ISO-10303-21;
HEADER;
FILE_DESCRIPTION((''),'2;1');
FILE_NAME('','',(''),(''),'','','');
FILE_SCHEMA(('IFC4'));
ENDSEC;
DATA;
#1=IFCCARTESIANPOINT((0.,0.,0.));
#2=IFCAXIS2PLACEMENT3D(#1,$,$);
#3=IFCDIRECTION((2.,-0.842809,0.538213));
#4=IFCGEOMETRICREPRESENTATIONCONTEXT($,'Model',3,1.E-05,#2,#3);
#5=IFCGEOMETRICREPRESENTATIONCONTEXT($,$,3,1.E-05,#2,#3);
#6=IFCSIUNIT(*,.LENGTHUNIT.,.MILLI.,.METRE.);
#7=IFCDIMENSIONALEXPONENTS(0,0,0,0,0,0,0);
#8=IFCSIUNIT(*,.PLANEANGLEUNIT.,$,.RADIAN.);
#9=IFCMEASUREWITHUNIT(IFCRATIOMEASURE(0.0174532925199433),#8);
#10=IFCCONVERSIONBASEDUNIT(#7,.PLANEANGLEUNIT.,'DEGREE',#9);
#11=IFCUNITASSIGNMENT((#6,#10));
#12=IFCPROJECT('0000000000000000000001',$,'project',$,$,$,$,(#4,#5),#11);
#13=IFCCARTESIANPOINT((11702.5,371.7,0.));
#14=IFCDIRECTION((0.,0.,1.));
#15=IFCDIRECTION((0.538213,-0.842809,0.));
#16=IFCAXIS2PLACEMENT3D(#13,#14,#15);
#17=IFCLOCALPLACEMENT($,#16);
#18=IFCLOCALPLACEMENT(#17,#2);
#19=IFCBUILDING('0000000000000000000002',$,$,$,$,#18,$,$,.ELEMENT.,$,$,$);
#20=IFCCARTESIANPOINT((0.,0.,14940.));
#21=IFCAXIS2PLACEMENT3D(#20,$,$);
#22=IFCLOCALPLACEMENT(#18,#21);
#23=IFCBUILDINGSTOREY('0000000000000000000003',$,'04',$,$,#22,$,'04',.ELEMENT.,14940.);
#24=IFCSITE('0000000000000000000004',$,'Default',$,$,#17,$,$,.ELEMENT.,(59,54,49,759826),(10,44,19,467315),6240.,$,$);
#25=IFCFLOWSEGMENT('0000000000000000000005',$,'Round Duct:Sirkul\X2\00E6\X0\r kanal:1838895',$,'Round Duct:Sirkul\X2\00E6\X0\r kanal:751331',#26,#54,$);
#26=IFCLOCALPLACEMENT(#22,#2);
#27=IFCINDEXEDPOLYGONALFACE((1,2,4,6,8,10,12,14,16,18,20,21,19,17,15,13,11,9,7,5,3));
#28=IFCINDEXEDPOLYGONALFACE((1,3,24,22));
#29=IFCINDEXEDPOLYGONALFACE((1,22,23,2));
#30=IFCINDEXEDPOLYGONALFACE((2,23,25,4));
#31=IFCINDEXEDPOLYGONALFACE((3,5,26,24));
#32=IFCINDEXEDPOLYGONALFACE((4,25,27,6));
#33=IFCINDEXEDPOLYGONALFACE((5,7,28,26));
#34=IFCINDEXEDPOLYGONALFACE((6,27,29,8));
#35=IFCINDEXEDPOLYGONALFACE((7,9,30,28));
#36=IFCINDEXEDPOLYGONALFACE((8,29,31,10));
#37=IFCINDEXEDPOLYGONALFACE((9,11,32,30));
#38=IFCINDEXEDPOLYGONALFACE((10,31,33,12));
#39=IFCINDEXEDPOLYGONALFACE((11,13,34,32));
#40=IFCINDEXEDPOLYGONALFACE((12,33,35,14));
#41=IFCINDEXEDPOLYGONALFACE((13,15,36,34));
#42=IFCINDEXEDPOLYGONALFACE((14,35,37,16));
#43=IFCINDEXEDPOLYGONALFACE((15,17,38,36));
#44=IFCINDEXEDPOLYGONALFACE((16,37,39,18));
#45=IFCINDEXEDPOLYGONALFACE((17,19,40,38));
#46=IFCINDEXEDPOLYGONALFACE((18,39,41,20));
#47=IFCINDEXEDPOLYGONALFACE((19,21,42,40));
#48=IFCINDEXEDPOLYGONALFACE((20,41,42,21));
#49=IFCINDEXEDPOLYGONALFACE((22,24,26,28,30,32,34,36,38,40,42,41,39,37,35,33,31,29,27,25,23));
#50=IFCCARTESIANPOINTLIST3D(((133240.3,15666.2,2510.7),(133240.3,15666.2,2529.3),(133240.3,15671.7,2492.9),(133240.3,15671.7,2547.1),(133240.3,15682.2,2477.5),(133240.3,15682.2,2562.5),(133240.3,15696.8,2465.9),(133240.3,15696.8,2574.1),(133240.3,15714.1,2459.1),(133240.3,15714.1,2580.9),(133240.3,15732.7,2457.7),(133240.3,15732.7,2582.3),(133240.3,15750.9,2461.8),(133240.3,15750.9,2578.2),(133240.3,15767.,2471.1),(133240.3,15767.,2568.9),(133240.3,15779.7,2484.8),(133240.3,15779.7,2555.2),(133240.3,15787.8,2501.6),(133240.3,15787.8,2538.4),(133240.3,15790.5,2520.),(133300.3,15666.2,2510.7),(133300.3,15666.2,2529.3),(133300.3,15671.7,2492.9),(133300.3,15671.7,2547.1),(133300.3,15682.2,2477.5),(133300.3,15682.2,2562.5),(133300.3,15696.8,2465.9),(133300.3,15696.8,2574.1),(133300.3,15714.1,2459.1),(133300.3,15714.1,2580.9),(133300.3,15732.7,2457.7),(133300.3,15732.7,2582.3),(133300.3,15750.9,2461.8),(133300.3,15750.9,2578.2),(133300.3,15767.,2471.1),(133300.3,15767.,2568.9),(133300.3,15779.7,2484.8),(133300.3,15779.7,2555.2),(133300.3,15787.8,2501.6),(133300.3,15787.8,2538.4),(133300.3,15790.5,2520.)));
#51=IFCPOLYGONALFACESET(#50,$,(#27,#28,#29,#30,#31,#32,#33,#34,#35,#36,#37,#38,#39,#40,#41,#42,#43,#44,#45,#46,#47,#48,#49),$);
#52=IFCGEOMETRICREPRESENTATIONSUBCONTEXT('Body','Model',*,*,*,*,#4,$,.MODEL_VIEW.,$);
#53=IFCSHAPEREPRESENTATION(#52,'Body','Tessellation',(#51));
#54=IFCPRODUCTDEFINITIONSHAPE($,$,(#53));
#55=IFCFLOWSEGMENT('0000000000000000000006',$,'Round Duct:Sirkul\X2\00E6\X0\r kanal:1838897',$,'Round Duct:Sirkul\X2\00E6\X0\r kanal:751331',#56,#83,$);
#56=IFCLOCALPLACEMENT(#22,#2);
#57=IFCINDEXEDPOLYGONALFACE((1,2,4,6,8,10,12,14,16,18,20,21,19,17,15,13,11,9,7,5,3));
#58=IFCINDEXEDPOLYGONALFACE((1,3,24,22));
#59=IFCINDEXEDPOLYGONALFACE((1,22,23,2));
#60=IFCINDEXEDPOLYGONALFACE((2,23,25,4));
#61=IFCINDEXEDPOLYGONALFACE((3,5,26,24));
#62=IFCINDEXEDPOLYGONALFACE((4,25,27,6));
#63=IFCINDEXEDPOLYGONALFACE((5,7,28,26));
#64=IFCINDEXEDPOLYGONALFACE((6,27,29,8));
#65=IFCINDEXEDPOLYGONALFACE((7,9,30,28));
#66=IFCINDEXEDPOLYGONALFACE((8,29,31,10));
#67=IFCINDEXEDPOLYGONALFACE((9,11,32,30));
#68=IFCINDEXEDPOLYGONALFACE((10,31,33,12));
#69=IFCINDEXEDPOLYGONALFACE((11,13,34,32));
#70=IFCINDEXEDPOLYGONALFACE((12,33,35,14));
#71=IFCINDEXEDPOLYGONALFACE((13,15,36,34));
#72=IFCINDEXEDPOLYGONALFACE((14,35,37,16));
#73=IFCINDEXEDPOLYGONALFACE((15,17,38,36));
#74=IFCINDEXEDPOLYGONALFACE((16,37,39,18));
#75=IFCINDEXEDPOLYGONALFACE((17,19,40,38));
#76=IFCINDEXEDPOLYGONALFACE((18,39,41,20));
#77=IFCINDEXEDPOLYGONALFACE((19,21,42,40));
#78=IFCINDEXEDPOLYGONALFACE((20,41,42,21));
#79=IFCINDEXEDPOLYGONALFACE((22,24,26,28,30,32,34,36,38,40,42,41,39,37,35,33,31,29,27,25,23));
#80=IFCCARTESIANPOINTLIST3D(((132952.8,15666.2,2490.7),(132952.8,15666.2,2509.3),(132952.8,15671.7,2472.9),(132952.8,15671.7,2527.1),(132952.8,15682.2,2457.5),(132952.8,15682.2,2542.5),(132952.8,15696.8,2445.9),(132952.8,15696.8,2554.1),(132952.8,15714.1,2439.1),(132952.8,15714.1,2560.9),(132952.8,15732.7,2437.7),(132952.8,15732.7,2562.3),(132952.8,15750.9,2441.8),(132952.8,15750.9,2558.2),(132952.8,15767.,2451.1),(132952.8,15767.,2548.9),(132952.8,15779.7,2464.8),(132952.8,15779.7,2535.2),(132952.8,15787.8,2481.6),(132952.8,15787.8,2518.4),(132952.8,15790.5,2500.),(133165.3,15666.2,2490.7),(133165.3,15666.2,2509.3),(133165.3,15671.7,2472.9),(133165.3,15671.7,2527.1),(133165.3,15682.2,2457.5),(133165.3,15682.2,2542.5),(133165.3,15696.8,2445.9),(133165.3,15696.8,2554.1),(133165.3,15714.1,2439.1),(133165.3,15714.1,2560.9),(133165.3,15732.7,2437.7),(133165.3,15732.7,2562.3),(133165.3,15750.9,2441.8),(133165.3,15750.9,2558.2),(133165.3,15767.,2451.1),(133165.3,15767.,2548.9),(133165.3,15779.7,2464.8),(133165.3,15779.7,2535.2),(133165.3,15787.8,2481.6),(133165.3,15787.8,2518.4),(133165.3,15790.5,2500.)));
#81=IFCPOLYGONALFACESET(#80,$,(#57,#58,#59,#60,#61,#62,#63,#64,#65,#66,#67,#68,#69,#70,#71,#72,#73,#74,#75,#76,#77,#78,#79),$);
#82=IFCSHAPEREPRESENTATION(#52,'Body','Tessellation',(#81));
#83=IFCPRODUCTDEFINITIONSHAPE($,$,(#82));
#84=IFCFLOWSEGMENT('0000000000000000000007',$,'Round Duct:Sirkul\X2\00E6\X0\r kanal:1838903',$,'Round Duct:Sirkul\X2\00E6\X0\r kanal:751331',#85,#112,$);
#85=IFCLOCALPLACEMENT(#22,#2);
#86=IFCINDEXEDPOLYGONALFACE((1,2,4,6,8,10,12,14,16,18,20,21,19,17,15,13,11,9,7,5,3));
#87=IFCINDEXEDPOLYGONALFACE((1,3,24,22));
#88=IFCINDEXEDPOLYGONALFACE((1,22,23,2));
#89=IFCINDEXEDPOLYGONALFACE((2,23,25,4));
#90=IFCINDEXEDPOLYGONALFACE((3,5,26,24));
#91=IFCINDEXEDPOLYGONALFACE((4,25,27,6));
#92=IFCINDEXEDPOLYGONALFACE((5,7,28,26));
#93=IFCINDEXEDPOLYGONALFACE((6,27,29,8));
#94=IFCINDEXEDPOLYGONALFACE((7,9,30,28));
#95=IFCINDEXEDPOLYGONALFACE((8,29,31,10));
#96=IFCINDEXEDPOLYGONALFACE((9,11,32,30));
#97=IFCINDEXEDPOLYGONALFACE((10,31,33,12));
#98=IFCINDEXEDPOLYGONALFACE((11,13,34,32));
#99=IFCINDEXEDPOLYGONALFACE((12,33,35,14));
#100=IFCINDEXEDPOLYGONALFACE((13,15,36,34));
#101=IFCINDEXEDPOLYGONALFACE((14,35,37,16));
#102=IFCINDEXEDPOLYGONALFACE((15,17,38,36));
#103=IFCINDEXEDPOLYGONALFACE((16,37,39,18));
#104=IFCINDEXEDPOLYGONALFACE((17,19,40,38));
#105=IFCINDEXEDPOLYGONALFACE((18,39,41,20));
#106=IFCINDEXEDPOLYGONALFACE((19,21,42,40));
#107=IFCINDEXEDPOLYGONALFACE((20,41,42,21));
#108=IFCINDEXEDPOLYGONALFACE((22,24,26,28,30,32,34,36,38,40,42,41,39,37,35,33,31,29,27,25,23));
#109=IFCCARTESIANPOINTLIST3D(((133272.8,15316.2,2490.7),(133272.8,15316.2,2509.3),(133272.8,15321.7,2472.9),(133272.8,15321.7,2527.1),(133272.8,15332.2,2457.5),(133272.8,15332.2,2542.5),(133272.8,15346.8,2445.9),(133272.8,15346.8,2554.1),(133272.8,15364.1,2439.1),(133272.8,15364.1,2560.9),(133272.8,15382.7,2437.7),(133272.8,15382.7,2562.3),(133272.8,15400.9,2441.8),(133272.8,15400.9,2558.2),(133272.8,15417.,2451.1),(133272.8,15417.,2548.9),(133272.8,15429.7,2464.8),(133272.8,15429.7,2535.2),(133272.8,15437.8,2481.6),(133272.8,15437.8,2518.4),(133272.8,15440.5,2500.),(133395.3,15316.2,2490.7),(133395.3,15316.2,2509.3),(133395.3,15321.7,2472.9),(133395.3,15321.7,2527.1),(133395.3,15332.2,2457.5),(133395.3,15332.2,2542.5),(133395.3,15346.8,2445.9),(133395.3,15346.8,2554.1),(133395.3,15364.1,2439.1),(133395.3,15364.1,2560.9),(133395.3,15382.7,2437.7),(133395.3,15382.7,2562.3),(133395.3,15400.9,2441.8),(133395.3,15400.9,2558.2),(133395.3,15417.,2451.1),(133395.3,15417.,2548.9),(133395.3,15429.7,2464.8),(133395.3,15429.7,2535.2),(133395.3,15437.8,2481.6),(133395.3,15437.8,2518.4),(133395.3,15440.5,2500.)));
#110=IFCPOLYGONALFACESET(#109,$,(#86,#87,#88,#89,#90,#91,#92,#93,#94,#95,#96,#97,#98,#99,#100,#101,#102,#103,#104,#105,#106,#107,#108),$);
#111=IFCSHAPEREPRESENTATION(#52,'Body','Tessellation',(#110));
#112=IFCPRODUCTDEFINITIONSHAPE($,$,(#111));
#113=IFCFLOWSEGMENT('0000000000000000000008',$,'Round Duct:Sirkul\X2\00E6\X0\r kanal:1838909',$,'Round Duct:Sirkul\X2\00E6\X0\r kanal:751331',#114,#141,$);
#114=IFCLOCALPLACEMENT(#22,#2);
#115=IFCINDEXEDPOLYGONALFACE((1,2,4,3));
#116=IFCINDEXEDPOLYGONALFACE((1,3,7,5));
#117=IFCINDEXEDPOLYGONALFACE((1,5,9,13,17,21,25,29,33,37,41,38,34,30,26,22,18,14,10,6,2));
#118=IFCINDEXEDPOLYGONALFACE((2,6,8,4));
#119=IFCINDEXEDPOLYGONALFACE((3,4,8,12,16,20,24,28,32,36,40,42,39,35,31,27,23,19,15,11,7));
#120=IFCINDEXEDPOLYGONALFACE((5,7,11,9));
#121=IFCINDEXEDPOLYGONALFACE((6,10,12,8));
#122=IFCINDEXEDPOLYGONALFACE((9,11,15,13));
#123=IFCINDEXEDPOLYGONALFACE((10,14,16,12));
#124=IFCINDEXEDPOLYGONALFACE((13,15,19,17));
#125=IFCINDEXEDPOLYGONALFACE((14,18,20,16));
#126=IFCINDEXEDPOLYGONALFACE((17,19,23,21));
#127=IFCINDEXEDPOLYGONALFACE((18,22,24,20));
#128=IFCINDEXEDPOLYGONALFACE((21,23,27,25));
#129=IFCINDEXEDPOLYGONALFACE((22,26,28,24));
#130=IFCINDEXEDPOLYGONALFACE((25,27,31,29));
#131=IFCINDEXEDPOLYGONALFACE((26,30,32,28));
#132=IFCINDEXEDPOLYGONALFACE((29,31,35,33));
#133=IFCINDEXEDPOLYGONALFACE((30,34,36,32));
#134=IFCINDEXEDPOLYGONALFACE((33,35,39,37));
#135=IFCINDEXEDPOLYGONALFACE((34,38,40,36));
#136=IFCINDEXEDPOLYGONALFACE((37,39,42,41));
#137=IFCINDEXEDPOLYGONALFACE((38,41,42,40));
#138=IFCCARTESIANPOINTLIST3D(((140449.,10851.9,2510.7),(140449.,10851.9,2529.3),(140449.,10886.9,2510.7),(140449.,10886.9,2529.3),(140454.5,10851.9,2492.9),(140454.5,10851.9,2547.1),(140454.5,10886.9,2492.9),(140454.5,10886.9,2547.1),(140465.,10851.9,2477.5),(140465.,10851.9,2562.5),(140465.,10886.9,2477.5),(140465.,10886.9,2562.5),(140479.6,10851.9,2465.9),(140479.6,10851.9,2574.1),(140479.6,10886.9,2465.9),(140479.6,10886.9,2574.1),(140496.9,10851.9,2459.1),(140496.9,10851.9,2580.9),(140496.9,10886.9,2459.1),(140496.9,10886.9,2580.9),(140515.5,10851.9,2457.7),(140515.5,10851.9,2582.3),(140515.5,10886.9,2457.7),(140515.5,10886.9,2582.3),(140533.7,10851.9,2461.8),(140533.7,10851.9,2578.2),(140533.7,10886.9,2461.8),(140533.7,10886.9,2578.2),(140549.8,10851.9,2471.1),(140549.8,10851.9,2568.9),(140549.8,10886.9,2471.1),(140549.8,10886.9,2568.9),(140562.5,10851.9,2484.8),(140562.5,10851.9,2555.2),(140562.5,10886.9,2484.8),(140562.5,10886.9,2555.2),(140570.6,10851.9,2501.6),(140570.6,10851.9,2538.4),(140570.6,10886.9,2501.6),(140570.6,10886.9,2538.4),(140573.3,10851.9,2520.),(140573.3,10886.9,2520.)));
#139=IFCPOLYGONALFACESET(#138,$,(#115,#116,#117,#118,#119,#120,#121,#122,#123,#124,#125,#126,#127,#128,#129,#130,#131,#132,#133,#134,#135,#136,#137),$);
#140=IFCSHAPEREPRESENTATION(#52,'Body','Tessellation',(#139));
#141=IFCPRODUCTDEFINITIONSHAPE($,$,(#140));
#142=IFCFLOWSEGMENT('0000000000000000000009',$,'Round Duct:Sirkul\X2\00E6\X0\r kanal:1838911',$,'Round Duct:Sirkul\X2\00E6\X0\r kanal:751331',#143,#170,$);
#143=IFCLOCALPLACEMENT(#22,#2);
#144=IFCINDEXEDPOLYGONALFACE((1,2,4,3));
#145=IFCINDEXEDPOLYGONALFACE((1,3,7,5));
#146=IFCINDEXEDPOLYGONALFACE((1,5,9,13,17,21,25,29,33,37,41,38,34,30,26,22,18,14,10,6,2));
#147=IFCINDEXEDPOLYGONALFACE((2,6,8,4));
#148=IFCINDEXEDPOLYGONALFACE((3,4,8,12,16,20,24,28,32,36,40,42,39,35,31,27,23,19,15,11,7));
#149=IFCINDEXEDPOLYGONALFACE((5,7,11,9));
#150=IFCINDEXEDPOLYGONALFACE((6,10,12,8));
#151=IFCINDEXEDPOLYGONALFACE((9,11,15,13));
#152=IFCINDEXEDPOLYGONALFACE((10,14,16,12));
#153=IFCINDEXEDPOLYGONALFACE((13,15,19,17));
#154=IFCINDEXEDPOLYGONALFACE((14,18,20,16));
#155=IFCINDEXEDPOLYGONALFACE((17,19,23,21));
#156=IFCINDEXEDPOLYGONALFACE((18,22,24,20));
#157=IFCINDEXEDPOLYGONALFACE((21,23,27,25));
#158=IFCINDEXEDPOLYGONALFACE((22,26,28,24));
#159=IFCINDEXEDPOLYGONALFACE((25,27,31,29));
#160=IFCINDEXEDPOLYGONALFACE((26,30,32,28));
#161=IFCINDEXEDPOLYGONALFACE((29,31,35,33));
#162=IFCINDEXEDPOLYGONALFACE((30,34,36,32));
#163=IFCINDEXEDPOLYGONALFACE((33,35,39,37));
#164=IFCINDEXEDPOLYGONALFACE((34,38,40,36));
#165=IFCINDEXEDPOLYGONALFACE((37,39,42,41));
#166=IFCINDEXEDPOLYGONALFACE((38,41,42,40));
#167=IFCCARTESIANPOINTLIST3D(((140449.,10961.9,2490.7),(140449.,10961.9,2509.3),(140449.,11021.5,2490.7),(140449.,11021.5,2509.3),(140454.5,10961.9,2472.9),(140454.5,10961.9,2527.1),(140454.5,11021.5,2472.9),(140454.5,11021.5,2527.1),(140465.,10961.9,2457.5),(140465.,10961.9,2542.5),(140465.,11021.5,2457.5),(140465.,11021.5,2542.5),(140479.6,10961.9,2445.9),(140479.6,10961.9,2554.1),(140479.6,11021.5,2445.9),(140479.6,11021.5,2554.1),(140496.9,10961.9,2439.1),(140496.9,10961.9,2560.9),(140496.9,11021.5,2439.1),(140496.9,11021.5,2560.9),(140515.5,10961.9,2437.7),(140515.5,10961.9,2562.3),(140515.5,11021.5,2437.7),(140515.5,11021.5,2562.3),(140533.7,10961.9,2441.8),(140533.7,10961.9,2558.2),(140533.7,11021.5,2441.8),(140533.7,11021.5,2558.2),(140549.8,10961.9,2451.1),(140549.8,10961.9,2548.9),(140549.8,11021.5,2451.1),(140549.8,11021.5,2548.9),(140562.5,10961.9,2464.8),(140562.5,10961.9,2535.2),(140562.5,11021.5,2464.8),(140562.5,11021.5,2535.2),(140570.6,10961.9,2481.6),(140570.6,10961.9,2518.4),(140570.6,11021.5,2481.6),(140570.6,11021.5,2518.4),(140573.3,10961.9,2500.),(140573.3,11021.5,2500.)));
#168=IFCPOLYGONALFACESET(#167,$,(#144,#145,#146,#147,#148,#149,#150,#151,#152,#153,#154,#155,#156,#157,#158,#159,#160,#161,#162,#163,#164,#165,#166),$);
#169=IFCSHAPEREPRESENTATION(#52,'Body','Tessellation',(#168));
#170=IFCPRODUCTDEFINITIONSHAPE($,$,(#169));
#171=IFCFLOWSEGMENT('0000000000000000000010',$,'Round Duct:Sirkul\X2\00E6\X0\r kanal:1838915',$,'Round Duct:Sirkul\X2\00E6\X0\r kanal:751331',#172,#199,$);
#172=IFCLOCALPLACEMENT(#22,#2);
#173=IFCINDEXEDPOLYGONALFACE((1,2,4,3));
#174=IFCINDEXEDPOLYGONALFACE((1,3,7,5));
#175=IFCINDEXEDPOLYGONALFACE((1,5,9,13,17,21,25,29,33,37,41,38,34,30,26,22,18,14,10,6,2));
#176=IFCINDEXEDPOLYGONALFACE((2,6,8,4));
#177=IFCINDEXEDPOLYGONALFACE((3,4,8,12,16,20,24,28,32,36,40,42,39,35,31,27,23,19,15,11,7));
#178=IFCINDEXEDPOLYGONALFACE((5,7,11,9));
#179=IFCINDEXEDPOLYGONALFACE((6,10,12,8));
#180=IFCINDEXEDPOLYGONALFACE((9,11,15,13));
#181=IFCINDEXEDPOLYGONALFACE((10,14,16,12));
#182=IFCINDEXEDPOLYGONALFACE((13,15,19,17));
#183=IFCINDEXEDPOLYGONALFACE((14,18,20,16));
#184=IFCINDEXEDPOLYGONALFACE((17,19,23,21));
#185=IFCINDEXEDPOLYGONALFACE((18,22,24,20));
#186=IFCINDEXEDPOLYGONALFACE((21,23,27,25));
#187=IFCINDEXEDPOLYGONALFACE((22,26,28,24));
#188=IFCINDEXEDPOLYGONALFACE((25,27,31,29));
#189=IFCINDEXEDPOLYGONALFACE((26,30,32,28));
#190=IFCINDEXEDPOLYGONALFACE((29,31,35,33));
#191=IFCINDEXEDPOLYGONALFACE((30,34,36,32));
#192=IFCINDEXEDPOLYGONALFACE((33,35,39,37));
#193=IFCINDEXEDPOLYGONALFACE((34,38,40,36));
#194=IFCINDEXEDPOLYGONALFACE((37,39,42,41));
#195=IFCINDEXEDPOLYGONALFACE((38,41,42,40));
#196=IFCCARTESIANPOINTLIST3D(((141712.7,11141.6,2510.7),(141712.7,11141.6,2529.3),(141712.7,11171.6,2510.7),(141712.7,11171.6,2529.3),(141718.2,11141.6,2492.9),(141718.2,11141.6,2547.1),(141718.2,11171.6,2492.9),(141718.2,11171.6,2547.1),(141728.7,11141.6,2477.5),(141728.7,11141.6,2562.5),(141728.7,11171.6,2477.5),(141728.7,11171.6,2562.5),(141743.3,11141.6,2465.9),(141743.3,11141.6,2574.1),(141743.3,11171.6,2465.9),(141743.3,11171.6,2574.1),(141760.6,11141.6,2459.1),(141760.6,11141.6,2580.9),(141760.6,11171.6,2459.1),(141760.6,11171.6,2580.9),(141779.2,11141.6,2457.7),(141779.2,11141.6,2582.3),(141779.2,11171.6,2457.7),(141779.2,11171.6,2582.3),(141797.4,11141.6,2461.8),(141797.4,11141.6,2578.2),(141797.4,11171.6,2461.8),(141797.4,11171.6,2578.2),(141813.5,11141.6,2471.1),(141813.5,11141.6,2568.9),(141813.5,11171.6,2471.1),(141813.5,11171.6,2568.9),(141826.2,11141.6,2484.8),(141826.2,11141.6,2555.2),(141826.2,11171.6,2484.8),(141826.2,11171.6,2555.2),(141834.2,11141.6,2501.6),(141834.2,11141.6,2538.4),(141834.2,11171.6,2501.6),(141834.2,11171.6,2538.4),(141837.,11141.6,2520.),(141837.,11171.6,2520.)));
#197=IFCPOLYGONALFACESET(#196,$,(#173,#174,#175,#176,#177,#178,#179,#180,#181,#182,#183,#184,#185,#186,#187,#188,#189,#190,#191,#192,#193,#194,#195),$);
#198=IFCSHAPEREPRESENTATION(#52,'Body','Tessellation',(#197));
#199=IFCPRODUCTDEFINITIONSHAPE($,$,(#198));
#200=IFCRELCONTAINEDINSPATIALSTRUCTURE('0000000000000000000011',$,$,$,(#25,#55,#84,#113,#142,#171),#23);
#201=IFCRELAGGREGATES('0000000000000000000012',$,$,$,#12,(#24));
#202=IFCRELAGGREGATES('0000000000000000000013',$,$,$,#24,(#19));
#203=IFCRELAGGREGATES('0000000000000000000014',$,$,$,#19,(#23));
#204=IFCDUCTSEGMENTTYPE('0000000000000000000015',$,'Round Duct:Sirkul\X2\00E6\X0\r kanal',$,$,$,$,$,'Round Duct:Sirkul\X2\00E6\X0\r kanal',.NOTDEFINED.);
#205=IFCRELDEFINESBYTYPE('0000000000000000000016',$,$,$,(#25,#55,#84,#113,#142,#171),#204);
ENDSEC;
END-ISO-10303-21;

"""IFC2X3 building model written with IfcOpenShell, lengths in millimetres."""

from ifc_helpers import new_model, entity, si_unit, converted_unit, direction, frame, frame_2d, origin, origin_2d_with_axis, place, context, subcontext, project, spatial, circle, extrude, type_object, element, save


model = new_model("IFC2X3")

# Units and contexts
model_context = context("Model", 3, precision=1e-05, world=origin(), true_north=direction((2.0, -0.842809, 0.538213)))
context_of_model = context(None, 3, precision=1e-05, world=origin(), true_north=direction((2.0, -0.842809, 0.538213)))
body_context = subcontext(model_context, "Body", "Model", "MODEL_VIEW")
ifc_project = project(units=[si_unit("LENGTHUNIT", "METRE", prefix="MILLI"), converted_unit("PLANEANGLEUNIT", "DEGREE", entity("IfcRatioMeasure", 0.0174532925199433), si_unit("PLANEANGLEUNIT", "RADIAN"), dimensions=[0, 0, 0, 0, 0, 0, 0])], contexts=[model_context, context_of_model])

# Site, building, storey
site_placement = place(None, frame((11702.5, 371.7, 0.0), z_axis=(0.0, 0.0, 1.0), x_axis=(0.538213, -0.842809, 0.0)))
site = spatial("IfcSite", under=ifc_project, at=site_placement, Name="Default", CompositionType="ELEMENT", RefLatitude=(59, 54, 49, 759826), RefLongitude=(10, 44, 19, 467315), RefElevation=6240.0)
building_placement = place(site_placement, origin())
building = spatial("IfcBuilding", under=site, at=building_placement, CompositionType="ELEMENT")
storey_placement = place(building_placement, frame((0.0, 0.0, 14940.0)))
storey = spatial("IfcBuildingStorey", under=building, at=storey_placement, Name="04", LongName="04", CompositionType="ELEMENT", Elevation=14940.0)

# Flow segments
duct_segment_type_1 = type_object("IfcDuctSegmentType", Name="Round Duct:Sirkulær kanal", ElementType="Round Duct:Sirkulær kanal", PredefinedType="NOTDEFINED")
flow_segment_1_placement = place(storey_placement, origin())
element("IfcFlowSegment", 1, at=flow_segment_1_placement, inside=storey, type_object=duct_segment_type_1, Name="Round Duct:Sirkulær kanal:1838895", ObjectType="Round Duct:Sirkulær kanal:751331", context=body_context, shape_type="SweptSolid", body=[
    extrude(circle(Radius=62.5, at=frame_2d((0.0, 0.0), x_axis=(1.0, 0.0))), frame((133240.3, 15728.0, 2520.0), z_axis=(1.0, 0.0, 0.0), x_axis=(0.0, 1.0, 0.0)), (0.0, 0.0, 1.0), 60.0),
])
flow_segment_2_placement = place(storey_placement, origin())
element("IfcFlowSegment", 2, at=flow_segment_2_placement, inside=storey, type_object=duct_segment_type_1, Name="Round Duct:Sirkulær kanal:1838897", ObjectType="Round Duct:Sirkulær kanal:751331", context=body_context, shape_type="SweptSolid", body=[
    extrude(circle(Radius=62.5, at=frame_2d((0.0, 0.0), x_axis=(1.0, 0.0))), frame((132952.8, 15728.0, 2500.0), z_axis=(1.0, 0.0, 0.0), x_axis=(0.0, 1.0, 0.0)), (0.0, 0.0, 1.0), 212.5),
])
flow_segment_3_placement = place(storey_placement, origin())
element("IfcFlowSegment", 3, at=flow_segment_3_placement, inside=storey, type_object=duct_segment_type_1, Name="Round Duct:Sirkulær kanal:1838903", ObjectType="Round Duct:Sirkulær kanal:751331", context=body_context, shape_type="SweptSolid", body=[
    extrude(circle(Radius=62.5, at=frame_2d((0.0, 0.0), x_axis=(1.0, 0.0))), frame((133272.8, 15378.0, 2500.0), z_axis=(1.0, 0.0, 0.0), x_axis=(0.0, 1.0, 0.0)), (0.0, 0.0, 1.0), 122.5),
])
flow_segment_4_placement = place(storey_placement, origin())
element("IfcFlowSegment", 4, at=flow_segment_4_placement, inside=storey, type_object=duct_segment_type_1, Name="Round Duct:Sirkulær kanal:1838909", ObjectType="Round Duct:Sirkulær kanal:751331", context=body_context, shape_type="SweptSolid", body=[
    extrude(circle(Radius=62.5, at=frame_2d((0.0, 0.0), x_axis=(1.0, 0.0))), frame((140510.8, 10851.9, 2520.0), z_axis=(0.0, 1.0, 0.0), x_axis=(1.0, 0.0, 0.0)), (0.0, 0.0, 1.0), 35.0),
])
flow_segment_5_placement = place(storey_placement, origin())
element("IfcFlowSegment", 5, at=flow_segment_5_placement, inside=storey, type_object=duct_segment_type_1, Name="Round Duct:Sirkulær kanal:1838911", ObjectType="Round Duct:Sirkulær kanal:751331", context=body_context, shape_type="SweptSolid", body=[
    extrude(circle(Radius=62.5, at=origin_2d_with_axis()), frame((140510.8, 10961.9, 2500.0), z_axis=(0.0, 1.0, 0.0), x_axis=(1.0, 0.0, 0.0)), (0.0, 0.0, 1.0), 59.6),
])
flow_segment_6_placement = place(storey_placement, origin())
element("IfcFlowSegment", 6, at=flow_segment_6_placement, inside=storey, type_object=duct_segment_type_1, Name="Round Duct:Sirkulær kanal:1838915", ObjectType="Round Duct:Sirkulær kanal:751331", context=body_context, shape_type="SweptSolid", body=[
    extrude(circle(Radius=62.5, at=frame_2d((0.0, 0.0), x_axis=(1.0, 0.0))), frame((141774.5, 11141.6, 2520.0), z_axis=(0.0, 1.0, 0.0), x_axis=(1.0, 0.0, 0.0)), (0.0, 0.0, 1.0), 30.0),
])

save(model, "model.ifc")
